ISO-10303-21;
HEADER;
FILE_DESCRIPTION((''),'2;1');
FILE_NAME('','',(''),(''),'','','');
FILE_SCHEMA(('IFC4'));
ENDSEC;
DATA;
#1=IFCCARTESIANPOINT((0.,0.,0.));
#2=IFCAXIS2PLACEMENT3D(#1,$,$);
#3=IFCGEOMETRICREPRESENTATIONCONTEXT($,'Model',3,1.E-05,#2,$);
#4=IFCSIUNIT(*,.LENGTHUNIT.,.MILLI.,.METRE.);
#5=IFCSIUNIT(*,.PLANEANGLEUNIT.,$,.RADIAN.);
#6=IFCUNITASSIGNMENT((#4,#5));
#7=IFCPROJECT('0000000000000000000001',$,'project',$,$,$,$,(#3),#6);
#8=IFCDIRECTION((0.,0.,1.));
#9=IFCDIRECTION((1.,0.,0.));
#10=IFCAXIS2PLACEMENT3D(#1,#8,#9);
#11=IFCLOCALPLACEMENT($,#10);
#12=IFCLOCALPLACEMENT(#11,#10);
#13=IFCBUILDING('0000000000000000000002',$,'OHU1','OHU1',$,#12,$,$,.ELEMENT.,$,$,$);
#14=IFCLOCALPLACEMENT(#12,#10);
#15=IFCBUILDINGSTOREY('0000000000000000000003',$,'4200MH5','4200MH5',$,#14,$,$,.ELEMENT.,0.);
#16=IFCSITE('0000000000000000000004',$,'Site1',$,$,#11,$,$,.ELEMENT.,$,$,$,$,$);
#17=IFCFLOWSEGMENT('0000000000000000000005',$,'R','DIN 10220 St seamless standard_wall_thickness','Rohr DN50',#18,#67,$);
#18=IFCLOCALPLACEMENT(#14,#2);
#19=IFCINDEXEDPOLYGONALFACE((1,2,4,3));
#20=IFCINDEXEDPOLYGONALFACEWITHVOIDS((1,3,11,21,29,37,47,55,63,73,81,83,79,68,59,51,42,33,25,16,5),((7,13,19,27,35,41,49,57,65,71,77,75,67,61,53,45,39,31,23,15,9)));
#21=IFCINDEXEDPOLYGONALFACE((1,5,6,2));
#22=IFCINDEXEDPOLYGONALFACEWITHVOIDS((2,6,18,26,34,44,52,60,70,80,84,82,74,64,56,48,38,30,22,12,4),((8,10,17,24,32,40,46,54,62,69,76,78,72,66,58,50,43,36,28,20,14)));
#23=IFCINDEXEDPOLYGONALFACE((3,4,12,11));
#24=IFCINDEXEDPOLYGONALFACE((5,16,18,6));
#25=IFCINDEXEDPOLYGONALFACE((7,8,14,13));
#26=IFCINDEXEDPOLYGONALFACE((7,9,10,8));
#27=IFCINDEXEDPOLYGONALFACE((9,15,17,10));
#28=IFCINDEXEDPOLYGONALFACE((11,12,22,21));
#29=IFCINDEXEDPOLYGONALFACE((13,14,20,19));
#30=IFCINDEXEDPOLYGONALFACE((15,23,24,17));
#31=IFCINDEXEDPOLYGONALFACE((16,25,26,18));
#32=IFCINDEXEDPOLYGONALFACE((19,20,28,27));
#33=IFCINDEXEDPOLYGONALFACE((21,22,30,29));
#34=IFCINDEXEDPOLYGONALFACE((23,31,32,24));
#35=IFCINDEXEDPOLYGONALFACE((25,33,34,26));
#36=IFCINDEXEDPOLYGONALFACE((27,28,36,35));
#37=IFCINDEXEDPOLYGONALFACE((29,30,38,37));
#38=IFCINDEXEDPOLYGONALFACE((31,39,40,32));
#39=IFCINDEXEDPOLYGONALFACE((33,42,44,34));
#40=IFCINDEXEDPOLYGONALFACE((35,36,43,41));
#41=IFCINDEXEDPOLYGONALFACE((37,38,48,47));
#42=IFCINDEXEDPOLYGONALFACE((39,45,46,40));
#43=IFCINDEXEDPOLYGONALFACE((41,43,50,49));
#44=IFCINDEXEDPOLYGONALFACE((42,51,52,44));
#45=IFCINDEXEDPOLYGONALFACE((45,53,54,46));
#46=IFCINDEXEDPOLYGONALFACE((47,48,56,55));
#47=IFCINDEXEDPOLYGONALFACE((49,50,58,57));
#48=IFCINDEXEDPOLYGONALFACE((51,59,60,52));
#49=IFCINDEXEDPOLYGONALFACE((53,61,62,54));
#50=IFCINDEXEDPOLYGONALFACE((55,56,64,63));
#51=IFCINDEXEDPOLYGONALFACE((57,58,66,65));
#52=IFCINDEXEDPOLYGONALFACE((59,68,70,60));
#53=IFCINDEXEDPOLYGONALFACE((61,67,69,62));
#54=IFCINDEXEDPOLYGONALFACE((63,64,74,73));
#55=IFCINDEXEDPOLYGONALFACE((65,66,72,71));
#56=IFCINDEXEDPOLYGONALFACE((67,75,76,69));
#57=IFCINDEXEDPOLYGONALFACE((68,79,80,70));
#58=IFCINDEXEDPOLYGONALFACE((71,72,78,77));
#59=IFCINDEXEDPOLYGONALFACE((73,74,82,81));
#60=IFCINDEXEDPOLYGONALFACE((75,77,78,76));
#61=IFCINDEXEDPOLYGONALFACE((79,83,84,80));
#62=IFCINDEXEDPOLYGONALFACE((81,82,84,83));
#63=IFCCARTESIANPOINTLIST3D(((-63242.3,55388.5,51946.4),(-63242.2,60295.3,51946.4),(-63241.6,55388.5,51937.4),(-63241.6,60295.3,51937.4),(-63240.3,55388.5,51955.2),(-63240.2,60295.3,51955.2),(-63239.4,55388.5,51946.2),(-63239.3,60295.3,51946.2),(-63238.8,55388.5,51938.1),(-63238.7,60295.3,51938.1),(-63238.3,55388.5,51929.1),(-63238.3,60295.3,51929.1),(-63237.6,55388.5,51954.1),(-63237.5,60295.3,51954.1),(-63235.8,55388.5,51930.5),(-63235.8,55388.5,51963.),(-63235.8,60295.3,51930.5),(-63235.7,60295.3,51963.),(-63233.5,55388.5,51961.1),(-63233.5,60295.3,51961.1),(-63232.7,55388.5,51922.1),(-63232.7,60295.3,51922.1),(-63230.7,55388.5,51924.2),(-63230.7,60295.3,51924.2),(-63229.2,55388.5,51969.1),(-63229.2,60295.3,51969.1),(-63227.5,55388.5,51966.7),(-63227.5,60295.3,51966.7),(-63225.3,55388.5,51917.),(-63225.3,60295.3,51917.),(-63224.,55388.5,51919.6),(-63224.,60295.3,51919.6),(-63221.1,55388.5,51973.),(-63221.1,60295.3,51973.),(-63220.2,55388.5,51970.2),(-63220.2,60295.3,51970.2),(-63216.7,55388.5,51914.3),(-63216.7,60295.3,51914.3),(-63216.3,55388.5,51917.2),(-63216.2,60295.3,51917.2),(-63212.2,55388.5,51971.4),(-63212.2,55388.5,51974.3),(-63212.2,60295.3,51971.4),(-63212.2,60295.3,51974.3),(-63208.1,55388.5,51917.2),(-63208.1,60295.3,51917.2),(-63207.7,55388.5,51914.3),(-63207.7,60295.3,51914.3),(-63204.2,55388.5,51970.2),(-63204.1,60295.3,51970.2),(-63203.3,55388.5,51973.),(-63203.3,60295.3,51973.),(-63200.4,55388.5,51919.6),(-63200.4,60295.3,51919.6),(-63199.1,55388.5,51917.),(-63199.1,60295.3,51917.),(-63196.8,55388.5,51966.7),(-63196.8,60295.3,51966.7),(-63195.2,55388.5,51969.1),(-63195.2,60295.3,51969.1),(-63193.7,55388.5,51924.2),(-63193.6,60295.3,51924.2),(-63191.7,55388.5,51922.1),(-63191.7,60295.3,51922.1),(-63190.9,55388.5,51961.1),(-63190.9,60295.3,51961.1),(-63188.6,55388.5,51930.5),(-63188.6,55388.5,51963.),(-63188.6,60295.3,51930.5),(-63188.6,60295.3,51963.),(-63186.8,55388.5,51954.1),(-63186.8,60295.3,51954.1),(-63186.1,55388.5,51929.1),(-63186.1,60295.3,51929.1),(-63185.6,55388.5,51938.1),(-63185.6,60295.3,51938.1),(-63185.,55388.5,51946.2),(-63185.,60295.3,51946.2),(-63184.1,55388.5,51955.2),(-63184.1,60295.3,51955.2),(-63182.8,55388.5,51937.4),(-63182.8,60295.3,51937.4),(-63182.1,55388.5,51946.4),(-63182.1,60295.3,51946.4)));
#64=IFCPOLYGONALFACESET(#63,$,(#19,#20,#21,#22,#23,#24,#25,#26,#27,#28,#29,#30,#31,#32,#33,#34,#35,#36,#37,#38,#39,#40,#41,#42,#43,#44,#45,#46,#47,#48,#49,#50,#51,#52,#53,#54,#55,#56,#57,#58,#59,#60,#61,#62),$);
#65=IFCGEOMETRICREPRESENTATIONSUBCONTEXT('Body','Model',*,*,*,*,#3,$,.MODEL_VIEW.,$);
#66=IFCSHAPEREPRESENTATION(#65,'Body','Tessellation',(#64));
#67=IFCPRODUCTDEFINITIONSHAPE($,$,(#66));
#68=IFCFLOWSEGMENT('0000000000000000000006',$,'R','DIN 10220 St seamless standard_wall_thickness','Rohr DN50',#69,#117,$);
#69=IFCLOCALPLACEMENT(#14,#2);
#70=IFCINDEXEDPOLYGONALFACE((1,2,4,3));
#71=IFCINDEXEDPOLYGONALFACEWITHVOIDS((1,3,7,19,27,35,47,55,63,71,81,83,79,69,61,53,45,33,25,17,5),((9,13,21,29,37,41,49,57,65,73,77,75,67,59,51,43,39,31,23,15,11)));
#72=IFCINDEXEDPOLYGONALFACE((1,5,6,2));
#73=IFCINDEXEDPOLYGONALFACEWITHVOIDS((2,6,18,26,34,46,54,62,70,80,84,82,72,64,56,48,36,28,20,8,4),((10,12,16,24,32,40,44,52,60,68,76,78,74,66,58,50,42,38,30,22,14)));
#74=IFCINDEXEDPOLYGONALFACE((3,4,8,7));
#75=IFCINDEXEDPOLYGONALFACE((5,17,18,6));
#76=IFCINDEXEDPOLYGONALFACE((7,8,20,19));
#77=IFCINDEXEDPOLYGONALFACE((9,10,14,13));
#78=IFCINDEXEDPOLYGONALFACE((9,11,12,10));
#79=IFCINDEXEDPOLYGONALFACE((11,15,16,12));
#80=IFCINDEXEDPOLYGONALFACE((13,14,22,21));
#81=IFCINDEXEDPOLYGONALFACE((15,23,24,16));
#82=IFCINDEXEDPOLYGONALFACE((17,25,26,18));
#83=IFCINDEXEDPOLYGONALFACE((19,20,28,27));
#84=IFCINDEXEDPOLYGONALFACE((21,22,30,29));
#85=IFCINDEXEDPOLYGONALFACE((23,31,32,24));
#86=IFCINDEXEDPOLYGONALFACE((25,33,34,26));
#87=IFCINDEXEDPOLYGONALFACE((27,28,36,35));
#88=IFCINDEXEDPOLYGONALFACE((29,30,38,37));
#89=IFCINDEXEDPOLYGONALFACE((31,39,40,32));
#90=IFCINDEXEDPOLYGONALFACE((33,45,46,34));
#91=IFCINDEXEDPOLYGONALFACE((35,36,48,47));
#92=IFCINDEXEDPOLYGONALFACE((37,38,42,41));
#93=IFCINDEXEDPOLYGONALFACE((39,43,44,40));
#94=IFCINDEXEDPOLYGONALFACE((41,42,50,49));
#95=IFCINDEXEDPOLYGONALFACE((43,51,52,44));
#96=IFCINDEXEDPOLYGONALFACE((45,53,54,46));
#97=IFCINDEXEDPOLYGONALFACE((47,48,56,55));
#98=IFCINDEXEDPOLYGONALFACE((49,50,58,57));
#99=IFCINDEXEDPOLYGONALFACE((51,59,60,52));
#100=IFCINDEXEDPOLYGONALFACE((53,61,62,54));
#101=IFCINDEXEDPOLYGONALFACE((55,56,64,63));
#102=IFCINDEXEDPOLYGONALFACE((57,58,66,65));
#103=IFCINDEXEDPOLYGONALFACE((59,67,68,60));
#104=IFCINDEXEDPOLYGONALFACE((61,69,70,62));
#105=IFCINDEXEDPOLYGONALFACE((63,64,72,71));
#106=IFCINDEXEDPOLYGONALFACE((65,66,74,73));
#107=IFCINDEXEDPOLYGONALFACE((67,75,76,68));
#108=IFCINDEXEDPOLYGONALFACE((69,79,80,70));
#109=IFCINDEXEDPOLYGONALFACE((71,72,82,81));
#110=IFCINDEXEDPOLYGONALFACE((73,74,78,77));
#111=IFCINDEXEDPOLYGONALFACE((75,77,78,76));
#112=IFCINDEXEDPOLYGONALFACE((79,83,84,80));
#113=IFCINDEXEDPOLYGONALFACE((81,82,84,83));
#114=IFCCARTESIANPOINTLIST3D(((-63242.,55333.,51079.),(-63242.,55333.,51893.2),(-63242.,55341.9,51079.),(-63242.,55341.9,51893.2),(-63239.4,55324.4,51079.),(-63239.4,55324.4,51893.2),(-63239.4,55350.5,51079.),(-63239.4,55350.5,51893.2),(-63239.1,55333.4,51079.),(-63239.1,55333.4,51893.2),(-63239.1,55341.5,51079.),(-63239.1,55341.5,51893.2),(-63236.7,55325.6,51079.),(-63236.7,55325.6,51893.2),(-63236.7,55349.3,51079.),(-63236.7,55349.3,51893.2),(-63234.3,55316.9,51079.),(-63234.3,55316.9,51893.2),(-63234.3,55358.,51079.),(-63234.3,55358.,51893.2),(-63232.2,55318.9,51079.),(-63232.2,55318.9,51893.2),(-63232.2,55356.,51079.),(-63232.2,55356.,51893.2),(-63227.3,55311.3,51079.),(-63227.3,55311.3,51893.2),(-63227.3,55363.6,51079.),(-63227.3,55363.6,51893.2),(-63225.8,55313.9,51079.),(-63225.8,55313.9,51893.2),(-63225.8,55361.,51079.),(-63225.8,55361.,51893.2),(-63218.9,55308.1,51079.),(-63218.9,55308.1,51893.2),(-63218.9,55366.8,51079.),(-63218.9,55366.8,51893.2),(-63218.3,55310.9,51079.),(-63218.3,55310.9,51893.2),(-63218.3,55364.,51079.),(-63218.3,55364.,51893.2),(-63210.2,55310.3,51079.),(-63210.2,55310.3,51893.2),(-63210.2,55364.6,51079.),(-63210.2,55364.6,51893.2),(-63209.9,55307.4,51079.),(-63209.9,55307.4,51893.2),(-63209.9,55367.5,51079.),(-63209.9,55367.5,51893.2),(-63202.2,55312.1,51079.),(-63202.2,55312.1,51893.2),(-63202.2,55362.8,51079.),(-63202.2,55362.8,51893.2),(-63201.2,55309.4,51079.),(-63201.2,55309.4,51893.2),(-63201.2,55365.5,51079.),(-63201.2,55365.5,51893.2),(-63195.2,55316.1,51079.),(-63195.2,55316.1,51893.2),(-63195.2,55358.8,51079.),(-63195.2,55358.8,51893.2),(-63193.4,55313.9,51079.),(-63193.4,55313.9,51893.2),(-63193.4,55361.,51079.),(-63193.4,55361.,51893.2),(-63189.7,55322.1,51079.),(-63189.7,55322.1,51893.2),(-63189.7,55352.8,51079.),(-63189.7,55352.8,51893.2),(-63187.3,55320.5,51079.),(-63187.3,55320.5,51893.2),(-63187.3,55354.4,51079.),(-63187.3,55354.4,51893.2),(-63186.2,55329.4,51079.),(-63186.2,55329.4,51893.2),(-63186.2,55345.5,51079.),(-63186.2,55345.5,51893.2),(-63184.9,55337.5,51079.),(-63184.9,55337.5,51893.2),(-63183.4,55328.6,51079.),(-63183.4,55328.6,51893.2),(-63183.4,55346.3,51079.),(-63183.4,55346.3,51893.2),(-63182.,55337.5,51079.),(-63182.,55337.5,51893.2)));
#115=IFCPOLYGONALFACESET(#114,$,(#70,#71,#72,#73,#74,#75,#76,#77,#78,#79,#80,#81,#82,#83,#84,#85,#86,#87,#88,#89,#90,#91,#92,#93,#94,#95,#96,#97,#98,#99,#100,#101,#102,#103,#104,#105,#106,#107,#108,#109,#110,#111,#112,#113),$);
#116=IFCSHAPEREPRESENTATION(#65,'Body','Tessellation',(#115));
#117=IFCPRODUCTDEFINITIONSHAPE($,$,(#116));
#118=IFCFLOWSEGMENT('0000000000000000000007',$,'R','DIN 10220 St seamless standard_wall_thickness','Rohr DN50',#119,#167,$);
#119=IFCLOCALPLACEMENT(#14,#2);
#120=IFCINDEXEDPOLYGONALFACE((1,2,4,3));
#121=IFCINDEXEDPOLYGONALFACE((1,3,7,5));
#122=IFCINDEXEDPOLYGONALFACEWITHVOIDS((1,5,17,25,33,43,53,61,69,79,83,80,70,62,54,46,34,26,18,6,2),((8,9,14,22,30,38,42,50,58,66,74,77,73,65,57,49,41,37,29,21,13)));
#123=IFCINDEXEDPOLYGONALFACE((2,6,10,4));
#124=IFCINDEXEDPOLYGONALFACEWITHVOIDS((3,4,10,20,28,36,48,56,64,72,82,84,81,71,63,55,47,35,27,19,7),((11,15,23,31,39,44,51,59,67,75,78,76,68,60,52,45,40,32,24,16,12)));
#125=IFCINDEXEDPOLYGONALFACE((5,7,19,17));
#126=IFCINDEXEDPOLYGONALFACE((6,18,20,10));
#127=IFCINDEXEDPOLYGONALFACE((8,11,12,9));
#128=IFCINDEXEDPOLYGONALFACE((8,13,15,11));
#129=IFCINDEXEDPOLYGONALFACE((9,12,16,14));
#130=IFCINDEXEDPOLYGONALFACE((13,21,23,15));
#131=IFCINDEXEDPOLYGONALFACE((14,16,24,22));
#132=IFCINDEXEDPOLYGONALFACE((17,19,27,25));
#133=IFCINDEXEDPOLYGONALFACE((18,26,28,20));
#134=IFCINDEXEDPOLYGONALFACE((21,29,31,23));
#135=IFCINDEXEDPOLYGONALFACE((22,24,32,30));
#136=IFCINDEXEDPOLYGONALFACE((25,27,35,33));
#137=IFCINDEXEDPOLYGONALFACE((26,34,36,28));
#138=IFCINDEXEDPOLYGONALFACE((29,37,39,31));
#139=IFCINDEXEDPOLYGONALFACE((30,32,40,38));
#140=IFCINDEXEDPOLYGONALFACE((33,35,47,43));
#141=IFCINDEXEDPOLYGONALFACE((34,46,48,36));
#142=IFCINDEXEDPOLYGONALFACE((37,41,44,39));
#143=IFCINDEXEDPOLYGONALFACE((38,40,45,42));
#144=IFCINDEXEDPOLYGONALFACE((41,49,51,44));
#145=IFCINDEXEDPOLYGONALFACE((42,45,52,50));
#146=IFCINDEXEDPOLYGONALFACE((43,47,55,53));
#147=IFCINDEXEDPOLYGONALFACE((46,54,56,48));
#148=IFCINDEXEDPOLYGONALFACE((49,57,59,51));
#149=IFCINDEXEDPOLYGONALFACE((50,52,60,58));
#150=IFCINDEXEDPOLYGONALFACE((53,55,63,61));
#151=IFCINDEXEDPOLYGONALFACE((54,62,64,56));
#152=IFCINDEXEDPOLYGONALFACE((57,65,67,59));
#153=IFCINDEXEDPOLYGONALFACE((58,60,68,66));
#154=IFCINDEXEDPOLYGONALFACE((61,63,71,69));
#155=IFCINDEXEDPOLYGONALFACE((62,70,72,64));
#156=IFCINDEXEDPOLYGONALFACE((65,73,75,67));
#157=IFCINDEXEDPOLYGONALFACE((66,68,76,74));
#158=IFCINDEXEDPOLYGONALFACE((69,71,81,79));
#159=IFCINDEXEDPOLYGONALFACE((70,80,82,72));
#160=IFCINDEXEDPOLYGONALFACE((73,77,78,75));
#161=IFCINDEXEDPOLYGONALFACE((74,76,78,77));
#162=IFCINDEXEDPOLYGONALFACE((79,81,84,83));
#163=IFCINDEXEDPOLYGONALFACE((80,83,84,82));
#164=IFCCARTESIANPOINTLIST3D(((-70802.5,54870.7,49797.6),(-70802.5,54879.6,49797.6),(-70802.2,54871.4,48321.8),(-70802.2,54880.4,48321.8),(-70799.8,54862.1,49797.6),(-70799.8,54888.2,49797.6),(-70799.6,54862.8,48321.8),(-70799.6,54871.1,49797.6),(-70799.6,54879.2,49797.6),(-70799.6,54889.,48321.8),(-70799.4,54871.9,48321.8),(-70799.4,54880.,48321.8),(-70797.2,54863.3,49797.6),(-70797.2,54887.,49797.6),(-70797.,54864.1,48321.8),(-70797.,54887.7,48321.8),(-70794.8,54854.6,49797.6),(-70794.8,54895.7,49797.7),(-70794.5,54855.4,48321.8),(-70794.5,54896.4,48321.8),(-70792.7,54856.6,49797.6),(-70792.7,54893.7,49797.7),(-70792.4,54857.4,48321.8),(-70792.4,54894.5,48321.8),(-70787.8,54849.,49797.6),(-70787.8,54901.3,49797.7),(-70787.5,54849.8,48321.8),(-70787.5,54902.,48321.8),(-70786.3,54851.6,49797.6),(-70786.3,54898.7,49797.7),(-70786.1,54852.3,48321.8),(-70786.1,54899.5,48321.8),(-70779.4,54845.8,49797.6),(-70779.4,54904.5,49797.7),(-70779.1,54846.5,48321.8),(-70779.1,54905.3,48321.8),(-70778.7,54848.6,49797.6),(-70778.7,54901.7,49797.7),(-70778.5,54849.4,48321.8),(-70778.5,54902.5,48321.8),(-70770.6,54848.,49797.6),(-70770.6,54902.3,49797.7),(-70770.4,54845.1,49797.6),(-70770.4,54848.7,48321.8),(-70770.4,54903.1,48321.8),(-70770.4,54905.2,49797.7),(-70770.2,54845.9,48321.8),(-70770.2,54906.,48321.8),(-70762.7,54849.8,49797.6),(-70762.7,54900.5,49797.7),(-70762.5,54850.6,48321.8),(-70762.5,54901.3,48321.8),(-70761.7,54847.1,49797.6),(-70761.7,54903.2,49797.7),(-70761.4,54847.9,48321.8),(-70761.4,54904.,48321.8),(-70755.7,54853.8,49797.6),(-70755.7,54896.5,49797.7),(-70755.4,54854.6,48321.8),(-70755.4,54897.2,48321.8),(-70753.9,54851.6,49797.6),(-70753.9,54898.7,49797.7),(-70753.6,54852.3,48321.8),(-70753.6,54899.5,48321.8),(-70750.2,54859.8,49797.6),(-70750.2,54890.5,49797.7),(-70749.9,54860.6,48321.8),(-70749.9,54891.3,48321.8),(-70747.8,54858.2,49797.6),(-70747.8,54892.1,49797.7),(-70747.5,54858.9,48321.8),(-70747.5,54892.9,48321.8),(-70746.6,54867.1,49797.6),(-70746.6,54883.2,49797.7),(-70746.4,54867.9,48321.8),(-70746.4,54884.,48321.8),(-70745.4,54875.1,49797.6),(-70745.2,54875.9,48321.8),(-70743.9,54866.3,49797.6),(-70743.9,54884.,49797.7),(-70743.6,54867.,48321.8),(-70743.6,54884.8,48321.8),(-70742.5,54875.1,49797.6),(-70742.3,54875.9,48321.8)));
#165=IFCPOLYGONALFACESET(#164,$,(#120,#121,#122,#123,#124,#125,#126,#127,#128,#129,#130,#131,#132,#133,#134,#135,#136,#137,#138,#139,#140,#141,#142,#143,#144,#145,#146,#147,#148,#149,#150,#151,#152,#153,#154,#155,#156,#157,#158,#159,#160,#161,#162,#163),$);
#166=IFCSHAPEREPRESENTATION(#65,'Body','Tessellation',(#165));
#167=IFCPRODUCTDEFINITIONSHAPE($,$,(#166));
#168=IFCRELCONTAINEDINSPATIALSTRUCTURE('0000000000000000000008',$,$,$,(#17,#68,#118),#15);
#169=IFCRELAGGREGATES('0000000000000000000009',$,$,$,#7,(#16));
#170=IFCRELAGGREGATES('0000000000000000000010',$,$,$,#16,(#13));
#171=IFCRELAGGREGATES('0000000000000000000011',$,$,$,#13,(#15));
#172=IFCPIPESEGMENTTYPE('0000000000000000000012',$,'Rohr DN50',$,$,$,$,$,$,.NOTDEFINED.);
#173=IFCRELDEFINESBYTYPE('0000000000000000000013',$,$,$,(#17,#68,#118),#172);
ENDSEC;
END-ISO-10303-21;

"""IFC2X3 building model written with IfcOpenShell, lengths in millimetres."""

from ifc_helpers import new_model, si_unit, frame, origin, origin_with_axes, origin_2d_with_axis, place, context, subcontext, project, spatial, hollow_circle, extrude, type_object, element, save


model = new_model("IFC2X3")

# Units and contexts
model_context = context("Model", 3, precision=1e-05, world=origin())
body_context = subcontext(model_context, "Body", "Model", "MODEL_VIEW")
ifc_project = project(units=[si_unit("LENGTHUNIT", "METRE", prefix="MILLI"), si_unit("PLANEANGLEUNIT", "RADIAN")], contexts=[model_context])

# Site, building, storey
site_placement = place(None, origin_with_axes())
site = spatial("IfcSite", under=ifc_project, at=site_placement, Name="Site1", CompositionType="ELEMENT")
building_placement = place(site_placement, origin_with_axes())
building = spatial("IfcBuilding", under=site, at=building_placement, Name="OHU1", Description="OHU1", CompositionType="ELEMENT")
storey_placement = place(building_placement, origin_with_axes())
storey = spatial("IfcBuildingStorey", under=building, at=storey_placement, Name="4200MH5", Description="4200MH5", CompositionType="ELEMENT", Elevation=0.0)

# Flow segments
pipe_segment_type_1 = type_object("IfcPipeSegmentType", Name="Rohr DN50", PredefinedType="NOTDEFINED")
flow_segment_1_placement = place(storey_placement, frame((-63212.2, 57841.9, 51944.2), z_axis=(0.0, 0.0, 1.0), x_axis=(1.0, 0.0, 0.0)))
element("IfcFlowSegment", 1, at=flow_segment_1_placement, inside=storey, type_object=pipe_segment_type_1, Name="R", Description="DIN 10220 St seamless standard_wall_thickness", ObjectType="Rohr DN50", context=body_context, shape_type="SweptSolid", body=[
    extrude(hollow_circle(Radius=30.1, WallThickness=2.9, at=origin_2d_with_axis()), frame((0.0, -2453.4, 0.0), z_axis=(0.000003, 1.0, 0.0), x_axis=(0.0, 0.0, 1.0)), (0.0, 0.0, 1.0), 4906.9),
])
flow_segment_2_placement = place(storey_placement, frame((-63212.2, 55337.5, 51486.1), z_axis=(0.0, 0.0, 1.0), x_axis=(1.0, 0.0, 0.0)))
element("IfcFlowSegment", 2, at=flow_segment_2_placement, inside=storey, type_object=pipe_segment_type_1, Name="R", Description="DIN 10220 St seamless standard_wall_thickness", ObjectType="Rohr DN50", context=body_context, shape_type="SweptSolid", body=[
    extrude(hollow_circle(Radius=30.1, WallThickness=2.9, at=origin_2d_with_axis()), frame((0.0, 0.0, 407.1), z_axis=(0.0, 0.0, -1.0), x_axis=(1.0, 0.0, 0.0)), (0.0, 0.0, 1.0), 814.1),
])
flow_segment_3_placement = place(storey_placement, frame((-70772.6, 54875.5, 49059.7), z_axis=(0.0, 0.0, 1.0), x_axis=(1.0, 0.0, 0.0)))
element("IfcFlowSegment", 3, at=flow_segment_3_placement, inside=storey, type_object=pipe_segment_type_1, Name="R", Description="DIN 10220 St seamless standard_wall_thickness", ObjectType="Rohr DN50", context=body_context, shape_type="SweptSolid", body=[
    extrude(hollow_circle(Radius=30.1, WallThickness=2.9, at=origin_2d_with_axis()), frame((-0.1, -0.4, 737.9), z_axis=(0.00017, 0.000523, -1.0), x_axis=(1.0, 0.0, 0.0)), (0.0, 0.0, 1.0), 1475.9),
])

save(model, "model.ifc")
